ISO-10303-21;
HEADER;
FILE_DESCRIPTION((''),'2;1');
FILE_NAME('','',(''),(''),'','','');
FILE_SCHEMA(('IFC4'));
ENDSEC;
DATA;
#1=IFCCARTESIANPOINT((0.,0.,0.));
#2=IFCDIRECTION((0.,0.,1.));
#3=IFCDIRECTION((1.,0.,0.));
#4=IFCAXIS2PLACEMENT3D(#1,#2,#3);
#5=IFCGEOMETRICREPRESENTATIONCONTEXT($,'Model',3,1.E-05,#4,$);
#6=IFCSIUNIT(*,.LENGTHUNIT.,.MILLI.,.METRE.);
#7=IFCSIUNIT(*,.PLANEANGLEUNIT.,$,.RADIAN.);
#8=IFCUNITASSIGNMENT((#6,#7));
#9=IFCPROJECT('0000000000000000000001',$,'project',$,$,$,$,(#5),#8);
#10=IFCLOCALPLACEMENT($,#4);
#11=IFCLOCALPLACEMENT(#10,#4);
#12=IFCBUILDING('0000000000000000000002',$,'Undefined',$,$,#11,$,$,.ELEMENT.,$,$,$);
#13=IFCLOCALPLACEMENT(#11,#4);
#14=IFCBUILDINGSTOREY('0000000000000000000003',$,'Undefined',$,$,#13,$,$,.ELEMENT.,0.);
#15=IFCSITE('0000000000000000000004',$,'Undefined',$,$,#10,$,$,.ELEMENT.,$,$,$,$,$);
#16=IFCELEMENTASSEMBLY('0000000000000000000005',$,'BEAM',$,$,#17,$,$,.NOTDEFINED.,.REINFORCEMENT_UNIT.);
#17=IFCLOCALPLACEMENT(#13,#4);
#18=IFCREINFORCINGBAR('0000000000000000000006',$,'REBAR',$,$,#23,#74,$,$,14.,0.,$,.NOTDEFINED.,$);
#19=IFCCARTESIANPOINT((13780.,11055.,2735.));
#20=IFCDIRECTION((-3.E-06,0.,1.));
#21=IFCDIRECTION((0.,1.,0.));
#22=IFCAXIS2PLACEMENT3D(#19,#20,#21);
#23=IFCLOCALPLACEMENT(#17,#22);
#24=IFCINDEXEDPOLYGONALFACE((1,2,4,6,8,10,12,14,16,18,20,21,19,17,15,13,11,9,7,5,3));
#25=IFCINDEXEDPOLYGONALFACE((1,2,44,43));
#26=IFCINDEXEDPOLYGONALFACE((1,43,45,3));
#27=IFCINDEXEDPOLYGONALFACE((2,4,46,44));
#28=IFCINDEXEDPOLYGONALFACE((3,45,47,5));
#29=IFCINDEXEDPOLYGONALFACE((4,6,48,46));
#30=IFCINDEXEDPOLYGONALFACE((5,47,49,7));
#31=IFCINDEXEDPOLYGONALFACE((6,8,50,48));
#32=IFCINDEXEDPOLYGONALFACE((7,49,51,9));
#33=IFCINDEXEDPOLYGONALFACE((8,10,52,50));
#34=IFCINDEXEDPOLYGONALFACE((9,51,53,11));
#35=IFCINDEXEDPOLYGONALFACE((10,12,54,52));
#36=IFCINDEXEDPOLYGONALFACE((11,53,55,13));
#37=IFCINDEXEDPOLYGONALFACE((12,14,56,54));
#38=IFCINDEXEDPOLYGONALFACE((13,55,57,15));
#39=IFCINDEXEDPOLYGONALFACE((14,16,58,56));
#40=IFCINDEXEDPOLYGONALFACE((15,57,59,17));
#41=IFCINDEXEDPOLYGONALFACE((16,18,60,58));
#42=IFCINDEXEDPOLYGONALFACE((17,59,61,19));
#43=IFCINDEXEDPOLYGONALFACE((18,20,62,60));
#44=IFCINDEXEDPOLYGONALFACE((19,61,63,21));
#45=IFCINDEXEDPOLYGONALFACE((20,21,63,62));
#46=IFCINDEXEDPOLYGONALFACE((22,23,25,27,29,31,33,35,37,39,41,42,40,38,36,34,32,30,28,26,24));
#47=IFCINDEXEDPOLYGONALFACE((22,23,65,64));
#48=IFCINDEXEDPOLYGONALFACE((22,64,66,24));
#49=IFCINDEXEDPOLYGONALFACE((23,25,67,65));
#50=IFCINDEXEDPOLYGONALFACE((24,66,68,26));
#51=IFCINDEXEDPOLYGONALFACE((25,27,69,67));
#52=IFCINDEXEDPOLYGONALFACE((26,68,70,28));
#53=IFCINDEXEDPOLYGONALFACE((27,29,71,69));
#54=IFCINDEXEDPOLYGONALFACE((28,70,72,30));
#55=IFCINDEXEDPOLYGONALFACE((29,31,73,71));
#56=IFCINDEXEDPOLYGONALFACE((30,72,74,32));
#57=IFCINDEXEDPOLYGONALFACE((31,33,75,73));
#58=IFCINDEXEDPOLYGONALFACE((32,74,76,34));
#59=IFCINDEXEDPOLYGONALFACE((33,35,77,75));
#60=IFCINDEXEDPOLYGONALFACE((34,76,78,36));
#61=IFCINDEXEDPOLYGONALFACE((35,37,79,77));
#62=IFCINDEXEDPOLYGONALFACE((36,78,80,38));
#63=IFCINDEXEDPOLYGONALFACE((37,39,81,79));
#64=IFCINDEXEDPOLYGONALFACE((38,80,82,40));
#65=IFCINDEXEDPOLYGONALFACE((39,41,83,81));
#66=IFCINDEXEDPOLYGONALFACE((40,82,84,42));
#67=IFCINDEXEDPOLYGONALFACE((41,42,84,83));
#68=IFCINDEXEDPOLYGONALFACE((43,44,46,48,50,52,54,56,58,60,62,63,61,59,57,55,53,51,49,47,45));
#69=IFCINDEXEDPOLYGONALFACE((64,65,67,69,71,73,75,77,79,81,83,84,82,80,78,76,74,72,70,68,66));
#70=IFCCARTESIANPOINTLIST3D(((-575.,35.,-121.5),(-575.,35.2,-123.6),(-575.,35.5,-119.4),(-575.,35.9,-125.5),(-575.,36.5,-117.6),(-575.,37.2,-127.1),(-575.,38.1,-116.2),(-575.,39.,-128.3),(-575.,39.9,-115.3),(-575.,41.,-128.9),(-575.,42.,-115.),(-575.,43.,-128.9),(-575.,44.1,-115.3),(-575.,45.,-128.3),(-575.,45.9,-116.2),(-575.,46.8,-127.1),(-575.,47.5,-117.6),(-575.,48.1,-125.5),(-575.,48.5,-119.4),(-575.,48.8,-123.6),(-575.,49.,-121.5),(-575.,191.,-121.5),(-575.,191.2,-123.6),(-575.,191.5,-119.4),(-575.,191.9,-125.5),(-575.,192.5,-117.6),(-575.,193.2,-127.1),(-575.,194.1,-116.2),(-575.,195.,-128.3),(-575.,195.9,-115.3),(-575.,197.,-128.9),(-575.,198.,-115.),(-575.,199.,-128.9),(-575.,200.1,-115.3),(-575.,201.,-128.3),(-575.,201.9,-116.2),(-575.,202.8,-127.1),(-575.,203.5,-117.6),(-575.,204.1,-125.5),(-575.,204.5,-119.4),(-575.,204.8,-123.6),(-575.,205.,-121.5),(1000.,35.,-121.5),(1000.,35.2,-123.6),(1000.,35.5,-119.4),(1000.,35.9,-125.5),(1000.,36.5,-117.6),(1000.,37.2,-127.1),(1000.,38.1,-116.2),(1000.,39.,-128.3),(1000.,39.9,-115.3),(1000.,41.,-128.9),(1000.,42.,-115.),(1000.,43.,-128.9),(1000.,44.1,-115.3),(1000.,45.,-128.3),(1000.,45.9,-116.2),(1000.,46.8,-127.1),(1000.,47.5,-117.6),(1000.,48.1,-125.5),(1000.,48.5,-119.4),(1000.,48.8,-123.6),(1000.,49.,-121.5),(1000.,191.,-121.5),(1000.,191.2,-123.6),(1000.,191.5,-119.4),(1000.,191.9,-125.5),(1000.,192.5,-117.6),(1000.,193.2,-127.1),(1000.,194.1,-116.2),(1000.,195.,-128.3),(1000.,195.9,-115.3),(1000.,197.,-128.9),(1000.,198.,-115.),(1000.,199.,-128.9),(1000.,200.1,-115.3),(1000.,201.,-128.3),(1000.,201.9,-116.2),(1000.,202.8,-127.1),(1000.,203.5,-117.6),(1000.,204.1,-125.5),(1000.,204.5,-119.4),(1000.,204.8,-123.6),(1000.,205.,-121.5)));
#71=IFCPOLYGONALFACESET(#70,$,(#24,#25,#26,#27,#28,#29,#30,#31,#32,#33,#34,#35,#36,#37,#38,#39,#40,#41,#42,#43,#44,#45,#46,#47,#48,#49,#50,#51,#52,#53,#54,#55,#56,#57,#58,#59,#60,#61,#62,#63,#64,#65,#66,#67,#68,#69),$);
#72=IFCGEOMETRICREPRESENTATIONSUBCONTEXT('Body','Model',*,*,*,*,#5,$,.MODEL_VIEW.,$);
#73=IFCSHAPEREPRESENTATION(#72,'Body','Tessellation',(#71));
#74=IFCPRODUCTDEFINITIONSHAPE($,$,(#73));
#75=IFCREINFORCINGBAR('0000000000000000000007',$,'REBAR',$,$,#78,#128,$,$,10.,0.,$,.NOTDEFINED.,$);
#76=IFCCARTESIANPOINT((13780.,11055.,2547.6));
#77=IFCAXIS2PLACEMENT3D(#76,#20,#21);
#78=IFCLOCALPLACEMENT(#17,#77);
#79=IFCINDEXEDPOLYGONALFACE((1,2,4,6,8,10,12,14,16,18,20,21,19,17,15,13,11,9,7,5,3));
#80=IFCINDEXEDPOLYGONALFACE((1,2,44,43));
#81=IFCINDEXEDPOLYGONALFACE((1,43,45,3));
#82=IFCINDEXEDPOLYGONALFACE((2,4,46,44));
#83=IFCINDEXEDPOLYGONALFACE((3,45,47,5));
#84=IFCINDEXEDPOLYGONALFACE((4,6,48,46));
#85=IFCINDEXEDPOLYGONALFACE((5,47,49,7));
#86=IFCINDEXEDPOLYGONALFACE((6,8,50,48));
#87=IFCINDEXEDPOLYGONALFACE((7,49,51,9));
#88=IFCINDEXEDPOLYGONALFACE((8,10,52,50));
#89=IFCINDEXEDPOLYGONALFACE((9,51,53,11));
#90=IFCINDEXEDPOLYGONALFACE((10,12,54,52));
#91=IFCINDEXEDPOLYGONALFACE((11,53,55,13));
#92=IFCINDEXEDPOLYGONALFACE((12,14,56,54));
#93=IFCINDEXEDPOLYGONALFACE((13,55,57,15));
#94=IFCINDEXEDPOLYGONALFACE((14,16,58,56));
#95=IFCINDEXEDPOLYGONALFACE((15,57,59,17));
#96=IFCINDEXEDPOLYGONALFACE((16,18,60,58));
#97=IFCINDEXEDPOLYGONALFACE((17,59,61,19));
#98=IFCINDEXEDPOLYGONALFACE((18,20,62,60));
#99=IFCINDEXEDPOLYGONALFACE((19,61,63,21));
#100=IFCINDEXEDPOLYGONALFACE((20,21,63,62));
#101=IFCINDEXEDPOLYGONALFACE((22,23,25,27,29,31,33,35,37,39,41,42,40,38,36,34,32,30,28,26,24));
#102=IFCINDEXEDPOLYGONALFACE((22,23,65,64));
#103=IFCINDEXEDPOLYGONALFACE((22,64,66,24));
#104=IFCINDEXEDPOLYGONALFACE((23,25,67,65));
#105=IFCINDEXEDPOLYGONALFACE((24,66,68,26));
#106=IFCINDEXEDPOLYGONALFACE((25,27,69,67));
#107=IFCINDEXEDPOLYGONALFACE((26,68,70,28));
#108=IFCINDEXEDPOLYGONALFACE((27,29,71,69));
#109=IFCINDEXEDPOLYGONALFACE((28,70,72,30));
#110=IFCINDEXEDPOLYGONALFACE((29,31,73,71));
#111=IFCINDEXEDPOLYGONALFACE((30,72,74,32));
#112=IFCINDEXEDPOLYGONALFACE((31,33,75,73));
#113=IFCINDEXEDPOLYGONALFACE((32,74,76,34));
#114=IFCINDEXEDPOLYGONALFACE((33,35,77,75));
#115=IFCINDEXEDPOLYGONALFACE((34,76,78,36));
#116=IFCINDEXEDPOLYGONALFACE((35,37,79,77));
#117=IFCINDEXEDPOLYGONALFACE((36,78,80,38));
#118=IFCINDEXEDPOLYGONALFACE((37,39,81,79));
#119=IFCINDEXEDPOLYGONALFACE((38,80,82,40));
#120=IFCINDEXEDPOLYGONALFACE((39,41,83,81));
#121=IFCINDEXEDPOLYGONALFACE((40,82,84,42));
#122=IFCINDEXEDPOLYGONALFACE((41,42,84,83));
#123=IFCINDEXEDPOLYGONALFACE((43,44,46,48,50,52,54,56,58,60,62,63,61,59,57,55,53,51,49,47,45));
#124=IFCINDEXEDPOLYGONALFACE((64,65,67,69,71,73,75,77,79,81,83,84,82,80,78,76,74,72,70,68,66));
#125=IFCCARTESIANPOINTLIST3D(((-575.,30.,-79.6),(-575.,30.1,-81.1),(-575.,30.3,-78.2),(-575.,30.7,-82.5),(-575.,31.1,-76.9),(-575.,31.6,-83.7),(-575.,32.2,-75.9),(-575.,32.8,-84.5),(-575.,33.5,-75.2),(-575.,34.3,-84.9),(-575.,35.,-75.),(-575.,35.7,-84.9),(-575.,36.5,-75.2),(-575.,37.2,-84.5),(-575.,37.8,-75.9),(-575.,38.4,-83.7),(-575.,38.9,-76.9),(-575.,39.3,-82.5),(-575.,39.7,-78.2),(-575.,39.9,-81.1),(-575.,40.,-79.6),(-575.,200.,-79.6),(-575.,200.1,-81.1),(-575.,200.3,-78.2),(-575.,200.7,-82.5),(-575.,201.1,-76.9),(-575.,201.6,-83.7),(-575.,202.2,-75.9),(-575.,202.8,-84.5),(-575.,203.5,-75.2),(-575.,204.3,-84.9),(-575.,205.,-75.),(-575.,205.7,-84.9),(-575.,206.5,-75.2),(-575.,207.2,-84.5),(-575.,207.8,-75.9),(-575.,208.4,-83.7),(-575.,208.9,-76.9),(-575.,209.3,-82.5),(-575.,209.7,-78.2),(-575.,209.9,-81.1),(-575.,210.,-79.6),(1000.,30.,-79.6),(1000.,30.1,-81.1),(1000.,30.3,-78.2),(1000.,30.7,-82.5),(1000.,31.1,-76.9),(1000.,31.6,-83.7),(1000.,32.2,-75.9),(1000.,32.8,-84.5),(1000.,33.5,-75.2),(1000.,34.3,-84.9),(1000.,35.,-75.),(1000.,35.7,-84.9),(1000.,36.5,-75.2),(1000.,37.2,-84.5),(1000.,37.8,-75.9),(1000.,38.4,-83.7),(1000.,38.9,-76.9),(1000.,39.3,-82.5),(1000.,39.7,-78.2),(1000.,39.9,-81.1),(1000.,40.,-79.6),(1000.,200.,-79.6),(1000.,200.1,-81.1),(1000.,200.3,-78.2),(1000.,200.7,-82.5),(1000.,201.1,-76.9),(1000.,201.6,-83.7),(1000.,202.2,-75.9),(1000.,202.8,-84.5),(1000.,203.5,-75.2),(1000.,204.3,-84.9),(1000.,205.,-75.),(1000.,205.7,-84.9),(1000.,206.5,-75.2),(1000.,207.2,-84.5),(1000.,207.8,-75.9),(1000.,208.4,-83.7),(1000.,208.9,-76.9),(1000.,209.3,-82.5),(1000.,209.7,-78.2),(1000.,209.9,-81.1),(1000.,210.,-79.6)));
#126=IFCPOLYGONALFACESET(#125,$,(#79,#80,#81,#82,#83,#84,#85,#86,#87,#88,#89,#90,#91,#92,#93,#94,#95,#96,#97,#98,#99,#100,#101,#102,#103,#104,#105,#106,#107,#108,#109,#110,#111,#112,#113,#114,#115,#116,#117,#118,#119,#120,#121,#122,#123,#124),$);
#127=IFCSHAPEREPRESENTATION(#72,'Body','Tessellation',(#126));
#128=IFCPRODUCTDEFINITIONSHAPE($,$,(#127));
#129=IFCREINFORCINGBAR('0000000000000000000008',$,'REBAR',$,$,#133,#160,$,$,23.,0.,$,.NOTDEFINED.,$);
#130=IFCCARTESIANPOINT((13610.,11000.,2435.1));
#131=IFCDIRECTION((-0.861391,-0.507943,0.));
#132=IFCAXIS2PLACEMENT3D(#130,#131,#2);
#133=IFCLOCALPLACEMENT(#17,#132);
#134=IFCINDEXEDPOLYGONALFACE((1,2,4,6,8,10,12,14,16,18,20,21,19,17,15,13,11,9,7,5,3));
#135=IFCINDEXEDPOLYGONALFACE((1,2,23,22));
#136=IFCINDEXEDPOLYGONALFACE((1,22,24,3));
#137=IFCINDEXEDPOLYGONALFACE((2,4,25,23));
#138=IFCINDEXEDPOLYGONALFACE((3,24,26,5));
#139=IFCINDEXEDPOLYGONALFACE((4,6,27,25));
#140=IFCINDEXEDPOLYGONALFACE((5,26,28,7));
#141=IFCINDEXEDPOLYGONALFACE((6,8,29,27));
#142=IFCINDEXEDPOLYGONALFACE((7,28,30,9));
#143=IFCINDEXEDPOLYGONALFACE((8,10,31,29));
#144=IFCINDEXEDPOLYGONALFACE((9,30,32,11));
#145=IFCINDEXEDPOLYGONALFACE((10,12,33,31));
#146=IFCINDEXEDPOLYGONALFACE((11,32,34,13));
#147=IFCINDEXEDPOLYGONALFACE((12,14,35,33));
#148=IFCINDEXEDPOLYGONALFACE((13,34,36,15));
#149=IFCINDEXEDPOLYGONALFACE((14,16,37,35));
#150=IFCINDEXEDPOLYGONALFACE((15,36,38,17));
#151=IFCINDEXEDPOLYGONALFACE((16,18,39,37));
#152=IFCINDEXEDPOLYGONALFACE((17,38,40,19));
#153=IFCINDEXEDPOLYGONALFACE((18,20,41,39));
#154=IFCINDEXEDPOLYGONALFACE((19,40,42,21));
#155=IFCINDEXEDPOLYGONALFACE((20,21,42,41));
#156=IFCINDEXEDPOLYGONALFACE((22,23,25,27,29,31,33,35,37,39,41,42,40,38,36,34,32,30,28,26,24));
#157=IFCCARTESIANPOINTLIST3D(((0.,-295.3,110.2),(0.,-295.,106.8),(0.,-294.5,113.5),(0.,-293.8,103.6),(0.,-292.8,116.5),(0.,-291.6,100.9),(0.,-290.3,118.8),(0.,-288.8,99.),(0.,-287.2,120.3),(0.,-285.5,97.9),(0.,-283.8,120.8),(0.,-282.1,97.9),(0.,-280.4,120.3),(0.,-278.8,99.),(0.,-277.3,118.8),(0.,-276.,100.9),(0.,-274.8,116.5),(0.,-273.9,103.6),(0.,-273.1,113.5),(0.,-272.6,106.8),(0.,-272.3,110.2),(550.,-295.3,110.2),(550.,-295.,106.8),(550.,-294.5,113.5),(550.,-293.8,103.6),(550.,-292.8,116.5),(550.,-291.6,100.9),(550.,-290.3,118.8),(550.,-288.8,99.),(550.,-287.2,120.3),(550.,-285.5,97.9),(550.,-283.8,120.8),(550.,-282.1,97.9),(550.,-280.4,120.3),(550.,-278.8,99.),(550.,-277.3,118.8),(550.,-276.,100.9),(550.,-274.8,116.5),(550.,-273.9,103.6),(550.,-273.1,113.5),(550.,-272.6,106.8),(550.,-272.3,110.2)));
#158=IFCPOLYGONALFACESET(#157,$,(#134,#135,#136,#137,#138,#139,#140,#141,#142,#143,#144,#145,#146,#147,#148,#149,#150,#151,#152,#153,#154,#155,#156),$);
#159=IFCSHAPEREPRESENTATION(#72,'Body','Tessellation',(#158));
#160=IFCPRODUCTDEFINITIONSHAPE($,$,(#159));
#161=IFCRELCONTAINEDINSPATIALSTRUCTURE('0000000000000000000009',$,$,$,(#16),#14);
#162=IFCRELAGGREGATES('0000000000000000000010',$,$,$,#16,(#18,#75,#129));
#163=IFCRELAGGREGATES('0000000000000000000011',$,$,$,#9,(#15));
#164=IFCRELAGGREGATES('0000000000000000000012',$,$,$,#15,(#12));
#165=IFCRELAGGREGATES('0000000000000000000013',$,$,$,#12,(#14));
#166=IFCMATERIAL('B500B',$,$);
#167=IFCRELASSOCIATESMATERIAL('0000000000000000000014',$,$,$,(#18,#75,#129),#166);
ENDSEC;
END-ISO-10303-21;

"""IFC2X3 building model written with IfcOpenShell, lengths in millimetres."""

from ifc_helpers import new_model, entity, si_unit, frame, origin_with_axes, place, context, subcontext, project, spatial, source, transform, mapped, material, element, aggregate, save


model = new_model("IFC2X3")

# Units and contexts
model_context = context("Model", 3, precision=1e-05, world=origin_with_axes())
body_context = subcontext(model_context, "Body", "Model", "MODEL_VIEW")
ifc_project = project(units=[si_unit("LENGTHUNIT", "METRE", prefix="MILLI"), si_unit("PLANEANGLEUNIT", "RADIAN")], contexts=[model_context])

# Site, building, storey
site_placement = place(None, origin_with_axes())
site = spatial("IfcSite", under=ifc_project, at=site_placement, Name="Undefined", CompositionType="ELEMENT")
building_placement = place(site_placement, origin_with_axes())
building = spatial("IfcBuilding", under=site, at=building_placement, Name="Undefined", CompositionType="ELEMENT")
storey_placement = place(building_placement, origin_with_axes())
storey = spatial("IfcBuildingStorey", under=building, at=storey_placement, Name="Undefined", CompositionType="ELEMENT", Elevation=0.0)

# Element assembly
assembly_1_placement = place(storey_placement, origin_with_axes())
assembly_1 = element("IfcElementAssembly", 1, at=assembly_1_placement, inside=storey, Name="BEAM", AssemblyPlace="NOTDEFINED", PredefinedType="REINFORCEMENT_UNIT")

# Reinforcing bars
ifc_material_1 = material(Name="B500B")
shared_shape_1 = source(origin_with_axes(), body_context, "Body", "AdvancedSweptSolid", [
    entity("IfcSweptDiskSolid", entity("IfcTrimmedCurve", entity("IfcLine", entity("IfcCartesianPoint", [0.0, 0.0, 0.0]), entity("IfcVector", entity("IfcDirection", [1.0, 0.0, 0.0]), 1.0)), [entity("IfcParameterValue", 0.0)], [entity("IfcParameterValue", 1574.999613)], True, "PARAMETER"), 7.0, None, 0.0, 1575.0),
])
shared_shape_2 = source(origin_with_axes(), body_context, "Body", "AdvancedSweptSolid", [
    entity("IfcSweptDiskSolid", entity("IfcTrimmedCurve", entity("IfcLine", entity("IfcCartesianPoint", [0.0, 0.0, 0.0]), entity("IfcVector", entity("IfcDirection", [1.0, 0.0, 0.0]), 1.0)), [entity("IfcParameterValue", 0.0)], [entity("IfcParameterValue", 1574.999613)], True, "PARAMETER"), 7.0, None, 0.0, 1575.0),
])
reinforcing_bar_1_placement = place(assembly_1_placement, frame((13780.0, 11055.0, 2735.0), z_axis=(-0.000003, 0.0, 1.0), x_axis=(0.0, 1.0, 0.0)))
reinforcing_bar_1 = element("IfcReinforcingBar", 2, at=reinforcing_bar_1_placement, material=ifc_material_1, Name="REBAR", BarRole="NOTDEFINED", CrossSectionArea=0.0, NominalDiameter=14.0, context=body_context, shape_type="MappedRepresentation", body=[
    mapped(shared_shape_1, transform((-575.0, 42.0, -122.0))),
    mapped(shared_shape_2, transform((-575.0, 198.0, -122.0))),
])
shared_shape_3 = source(origin_with_axes(), body_context, "Body", "AdvancedSweptSolid", [
    entity("IfcSweptDiskSolid", entity("IfcTrimmedCurve", entity("IfcLine", entity("IfcCartesianPoint", [0.0, 0.0, 0.0]), entity("IfcVector", entity("IfcDirection", [1.0, 0.0, 0.0]), 1.0)), [entity("IfcParameterValue", 0.0)], [entity("IfcParameterValue", 1574.999613)], True, "PARAMETER"), 5.0, None, 0.0, 1575.0),
])
shared_shape_4 = source(origin_with_axes(), body_context, "Body", "AdvancedSweptSolid", [
    entity("IfcSweptDiskSolid", entity("IfcTrimmedCurve", entity("IfcLine", entity("IfcCartesianPoint", [0.0, 0.0, 0.0]), entity("IfcVector", entity("IfcDirection", [1.0, 0.0, 0.0]), 1.0)), [entity("IfcParameterValue", 0.0)], [entity("IfcParameterValue", 1574.999613)], True, "PARAMETER"), 5.0, None, 0.0, 1575.0),
])
reinforcing_bar_2_placement = place(assembly_1_placement, frame((13780.0, 11055.0, 2547.6), z_axis=(-0.000003, 0.0, 1.0), x_axis=(0.0, 1.0, 0.0)))
reinforcing_bar_2 = element("IfcReinforcingBar", 3, at=reinforcing_bar_2_placement, material=ifc_material_1, Name="REBAR", BarRole="NOTDEFINED", CrossSectionArea=0.0, NominalDiameter=10.0, context=body_context, shape_type="MappedRepresentation", body=[
    mapped(shared_shape_3, transform((-575.0, 35.0, -80.0))),
    mapped(shared_shape_4, transform((-575.0, 205.0, -80.0))),
])
shared_shape_5 = source(origin_with_axes(), body_context, "Body", "AdvancedSweptSolid", [
    entity("IfcSweptDiskSolid", entity("IfcTrimmedCurve", entity("IfcLine", entity("IfcCartesianPoint", [0.0, 0.0, 0.0]), entity("IfcVector", entity("IfcDirection", [1.0, 0.0, 0.0]), 1.0)), [entity("IfcParameterValue", 0.0)], [entity("IfcParameterValue", 550.0)], True, "PARAMETER"), 11.5, None, 0.0, 550.0),
])
reinforcing_bar_3_placement = place(assembly_1_placement, frame((13610.0, 11000.0, 2435.1), z_axis=(-0.861391, -0.507943, 0.0), x_axis=(0.0, 0.0, 1.0)))
reinforcing_bar_3 = element("IfcReinforcingBar", 4, at=reinforcing_bar_3_placement, material=ifc_material_1, Name="REBAR", BarRole="NOTDEFINED", CrossSectionArea=0.0, NominalDiameter=23.0, context=body_context, shape_type="MappedRepresentation", body=[
    mapped(shared_shape_5, transform((0.0, -283.8, 109.3))),
])
aggregate(assembly_1, [reinforcing_bar_1, reinforcing_bar_2, reinforcing_bar_3])

save(model, "model.ifc")
